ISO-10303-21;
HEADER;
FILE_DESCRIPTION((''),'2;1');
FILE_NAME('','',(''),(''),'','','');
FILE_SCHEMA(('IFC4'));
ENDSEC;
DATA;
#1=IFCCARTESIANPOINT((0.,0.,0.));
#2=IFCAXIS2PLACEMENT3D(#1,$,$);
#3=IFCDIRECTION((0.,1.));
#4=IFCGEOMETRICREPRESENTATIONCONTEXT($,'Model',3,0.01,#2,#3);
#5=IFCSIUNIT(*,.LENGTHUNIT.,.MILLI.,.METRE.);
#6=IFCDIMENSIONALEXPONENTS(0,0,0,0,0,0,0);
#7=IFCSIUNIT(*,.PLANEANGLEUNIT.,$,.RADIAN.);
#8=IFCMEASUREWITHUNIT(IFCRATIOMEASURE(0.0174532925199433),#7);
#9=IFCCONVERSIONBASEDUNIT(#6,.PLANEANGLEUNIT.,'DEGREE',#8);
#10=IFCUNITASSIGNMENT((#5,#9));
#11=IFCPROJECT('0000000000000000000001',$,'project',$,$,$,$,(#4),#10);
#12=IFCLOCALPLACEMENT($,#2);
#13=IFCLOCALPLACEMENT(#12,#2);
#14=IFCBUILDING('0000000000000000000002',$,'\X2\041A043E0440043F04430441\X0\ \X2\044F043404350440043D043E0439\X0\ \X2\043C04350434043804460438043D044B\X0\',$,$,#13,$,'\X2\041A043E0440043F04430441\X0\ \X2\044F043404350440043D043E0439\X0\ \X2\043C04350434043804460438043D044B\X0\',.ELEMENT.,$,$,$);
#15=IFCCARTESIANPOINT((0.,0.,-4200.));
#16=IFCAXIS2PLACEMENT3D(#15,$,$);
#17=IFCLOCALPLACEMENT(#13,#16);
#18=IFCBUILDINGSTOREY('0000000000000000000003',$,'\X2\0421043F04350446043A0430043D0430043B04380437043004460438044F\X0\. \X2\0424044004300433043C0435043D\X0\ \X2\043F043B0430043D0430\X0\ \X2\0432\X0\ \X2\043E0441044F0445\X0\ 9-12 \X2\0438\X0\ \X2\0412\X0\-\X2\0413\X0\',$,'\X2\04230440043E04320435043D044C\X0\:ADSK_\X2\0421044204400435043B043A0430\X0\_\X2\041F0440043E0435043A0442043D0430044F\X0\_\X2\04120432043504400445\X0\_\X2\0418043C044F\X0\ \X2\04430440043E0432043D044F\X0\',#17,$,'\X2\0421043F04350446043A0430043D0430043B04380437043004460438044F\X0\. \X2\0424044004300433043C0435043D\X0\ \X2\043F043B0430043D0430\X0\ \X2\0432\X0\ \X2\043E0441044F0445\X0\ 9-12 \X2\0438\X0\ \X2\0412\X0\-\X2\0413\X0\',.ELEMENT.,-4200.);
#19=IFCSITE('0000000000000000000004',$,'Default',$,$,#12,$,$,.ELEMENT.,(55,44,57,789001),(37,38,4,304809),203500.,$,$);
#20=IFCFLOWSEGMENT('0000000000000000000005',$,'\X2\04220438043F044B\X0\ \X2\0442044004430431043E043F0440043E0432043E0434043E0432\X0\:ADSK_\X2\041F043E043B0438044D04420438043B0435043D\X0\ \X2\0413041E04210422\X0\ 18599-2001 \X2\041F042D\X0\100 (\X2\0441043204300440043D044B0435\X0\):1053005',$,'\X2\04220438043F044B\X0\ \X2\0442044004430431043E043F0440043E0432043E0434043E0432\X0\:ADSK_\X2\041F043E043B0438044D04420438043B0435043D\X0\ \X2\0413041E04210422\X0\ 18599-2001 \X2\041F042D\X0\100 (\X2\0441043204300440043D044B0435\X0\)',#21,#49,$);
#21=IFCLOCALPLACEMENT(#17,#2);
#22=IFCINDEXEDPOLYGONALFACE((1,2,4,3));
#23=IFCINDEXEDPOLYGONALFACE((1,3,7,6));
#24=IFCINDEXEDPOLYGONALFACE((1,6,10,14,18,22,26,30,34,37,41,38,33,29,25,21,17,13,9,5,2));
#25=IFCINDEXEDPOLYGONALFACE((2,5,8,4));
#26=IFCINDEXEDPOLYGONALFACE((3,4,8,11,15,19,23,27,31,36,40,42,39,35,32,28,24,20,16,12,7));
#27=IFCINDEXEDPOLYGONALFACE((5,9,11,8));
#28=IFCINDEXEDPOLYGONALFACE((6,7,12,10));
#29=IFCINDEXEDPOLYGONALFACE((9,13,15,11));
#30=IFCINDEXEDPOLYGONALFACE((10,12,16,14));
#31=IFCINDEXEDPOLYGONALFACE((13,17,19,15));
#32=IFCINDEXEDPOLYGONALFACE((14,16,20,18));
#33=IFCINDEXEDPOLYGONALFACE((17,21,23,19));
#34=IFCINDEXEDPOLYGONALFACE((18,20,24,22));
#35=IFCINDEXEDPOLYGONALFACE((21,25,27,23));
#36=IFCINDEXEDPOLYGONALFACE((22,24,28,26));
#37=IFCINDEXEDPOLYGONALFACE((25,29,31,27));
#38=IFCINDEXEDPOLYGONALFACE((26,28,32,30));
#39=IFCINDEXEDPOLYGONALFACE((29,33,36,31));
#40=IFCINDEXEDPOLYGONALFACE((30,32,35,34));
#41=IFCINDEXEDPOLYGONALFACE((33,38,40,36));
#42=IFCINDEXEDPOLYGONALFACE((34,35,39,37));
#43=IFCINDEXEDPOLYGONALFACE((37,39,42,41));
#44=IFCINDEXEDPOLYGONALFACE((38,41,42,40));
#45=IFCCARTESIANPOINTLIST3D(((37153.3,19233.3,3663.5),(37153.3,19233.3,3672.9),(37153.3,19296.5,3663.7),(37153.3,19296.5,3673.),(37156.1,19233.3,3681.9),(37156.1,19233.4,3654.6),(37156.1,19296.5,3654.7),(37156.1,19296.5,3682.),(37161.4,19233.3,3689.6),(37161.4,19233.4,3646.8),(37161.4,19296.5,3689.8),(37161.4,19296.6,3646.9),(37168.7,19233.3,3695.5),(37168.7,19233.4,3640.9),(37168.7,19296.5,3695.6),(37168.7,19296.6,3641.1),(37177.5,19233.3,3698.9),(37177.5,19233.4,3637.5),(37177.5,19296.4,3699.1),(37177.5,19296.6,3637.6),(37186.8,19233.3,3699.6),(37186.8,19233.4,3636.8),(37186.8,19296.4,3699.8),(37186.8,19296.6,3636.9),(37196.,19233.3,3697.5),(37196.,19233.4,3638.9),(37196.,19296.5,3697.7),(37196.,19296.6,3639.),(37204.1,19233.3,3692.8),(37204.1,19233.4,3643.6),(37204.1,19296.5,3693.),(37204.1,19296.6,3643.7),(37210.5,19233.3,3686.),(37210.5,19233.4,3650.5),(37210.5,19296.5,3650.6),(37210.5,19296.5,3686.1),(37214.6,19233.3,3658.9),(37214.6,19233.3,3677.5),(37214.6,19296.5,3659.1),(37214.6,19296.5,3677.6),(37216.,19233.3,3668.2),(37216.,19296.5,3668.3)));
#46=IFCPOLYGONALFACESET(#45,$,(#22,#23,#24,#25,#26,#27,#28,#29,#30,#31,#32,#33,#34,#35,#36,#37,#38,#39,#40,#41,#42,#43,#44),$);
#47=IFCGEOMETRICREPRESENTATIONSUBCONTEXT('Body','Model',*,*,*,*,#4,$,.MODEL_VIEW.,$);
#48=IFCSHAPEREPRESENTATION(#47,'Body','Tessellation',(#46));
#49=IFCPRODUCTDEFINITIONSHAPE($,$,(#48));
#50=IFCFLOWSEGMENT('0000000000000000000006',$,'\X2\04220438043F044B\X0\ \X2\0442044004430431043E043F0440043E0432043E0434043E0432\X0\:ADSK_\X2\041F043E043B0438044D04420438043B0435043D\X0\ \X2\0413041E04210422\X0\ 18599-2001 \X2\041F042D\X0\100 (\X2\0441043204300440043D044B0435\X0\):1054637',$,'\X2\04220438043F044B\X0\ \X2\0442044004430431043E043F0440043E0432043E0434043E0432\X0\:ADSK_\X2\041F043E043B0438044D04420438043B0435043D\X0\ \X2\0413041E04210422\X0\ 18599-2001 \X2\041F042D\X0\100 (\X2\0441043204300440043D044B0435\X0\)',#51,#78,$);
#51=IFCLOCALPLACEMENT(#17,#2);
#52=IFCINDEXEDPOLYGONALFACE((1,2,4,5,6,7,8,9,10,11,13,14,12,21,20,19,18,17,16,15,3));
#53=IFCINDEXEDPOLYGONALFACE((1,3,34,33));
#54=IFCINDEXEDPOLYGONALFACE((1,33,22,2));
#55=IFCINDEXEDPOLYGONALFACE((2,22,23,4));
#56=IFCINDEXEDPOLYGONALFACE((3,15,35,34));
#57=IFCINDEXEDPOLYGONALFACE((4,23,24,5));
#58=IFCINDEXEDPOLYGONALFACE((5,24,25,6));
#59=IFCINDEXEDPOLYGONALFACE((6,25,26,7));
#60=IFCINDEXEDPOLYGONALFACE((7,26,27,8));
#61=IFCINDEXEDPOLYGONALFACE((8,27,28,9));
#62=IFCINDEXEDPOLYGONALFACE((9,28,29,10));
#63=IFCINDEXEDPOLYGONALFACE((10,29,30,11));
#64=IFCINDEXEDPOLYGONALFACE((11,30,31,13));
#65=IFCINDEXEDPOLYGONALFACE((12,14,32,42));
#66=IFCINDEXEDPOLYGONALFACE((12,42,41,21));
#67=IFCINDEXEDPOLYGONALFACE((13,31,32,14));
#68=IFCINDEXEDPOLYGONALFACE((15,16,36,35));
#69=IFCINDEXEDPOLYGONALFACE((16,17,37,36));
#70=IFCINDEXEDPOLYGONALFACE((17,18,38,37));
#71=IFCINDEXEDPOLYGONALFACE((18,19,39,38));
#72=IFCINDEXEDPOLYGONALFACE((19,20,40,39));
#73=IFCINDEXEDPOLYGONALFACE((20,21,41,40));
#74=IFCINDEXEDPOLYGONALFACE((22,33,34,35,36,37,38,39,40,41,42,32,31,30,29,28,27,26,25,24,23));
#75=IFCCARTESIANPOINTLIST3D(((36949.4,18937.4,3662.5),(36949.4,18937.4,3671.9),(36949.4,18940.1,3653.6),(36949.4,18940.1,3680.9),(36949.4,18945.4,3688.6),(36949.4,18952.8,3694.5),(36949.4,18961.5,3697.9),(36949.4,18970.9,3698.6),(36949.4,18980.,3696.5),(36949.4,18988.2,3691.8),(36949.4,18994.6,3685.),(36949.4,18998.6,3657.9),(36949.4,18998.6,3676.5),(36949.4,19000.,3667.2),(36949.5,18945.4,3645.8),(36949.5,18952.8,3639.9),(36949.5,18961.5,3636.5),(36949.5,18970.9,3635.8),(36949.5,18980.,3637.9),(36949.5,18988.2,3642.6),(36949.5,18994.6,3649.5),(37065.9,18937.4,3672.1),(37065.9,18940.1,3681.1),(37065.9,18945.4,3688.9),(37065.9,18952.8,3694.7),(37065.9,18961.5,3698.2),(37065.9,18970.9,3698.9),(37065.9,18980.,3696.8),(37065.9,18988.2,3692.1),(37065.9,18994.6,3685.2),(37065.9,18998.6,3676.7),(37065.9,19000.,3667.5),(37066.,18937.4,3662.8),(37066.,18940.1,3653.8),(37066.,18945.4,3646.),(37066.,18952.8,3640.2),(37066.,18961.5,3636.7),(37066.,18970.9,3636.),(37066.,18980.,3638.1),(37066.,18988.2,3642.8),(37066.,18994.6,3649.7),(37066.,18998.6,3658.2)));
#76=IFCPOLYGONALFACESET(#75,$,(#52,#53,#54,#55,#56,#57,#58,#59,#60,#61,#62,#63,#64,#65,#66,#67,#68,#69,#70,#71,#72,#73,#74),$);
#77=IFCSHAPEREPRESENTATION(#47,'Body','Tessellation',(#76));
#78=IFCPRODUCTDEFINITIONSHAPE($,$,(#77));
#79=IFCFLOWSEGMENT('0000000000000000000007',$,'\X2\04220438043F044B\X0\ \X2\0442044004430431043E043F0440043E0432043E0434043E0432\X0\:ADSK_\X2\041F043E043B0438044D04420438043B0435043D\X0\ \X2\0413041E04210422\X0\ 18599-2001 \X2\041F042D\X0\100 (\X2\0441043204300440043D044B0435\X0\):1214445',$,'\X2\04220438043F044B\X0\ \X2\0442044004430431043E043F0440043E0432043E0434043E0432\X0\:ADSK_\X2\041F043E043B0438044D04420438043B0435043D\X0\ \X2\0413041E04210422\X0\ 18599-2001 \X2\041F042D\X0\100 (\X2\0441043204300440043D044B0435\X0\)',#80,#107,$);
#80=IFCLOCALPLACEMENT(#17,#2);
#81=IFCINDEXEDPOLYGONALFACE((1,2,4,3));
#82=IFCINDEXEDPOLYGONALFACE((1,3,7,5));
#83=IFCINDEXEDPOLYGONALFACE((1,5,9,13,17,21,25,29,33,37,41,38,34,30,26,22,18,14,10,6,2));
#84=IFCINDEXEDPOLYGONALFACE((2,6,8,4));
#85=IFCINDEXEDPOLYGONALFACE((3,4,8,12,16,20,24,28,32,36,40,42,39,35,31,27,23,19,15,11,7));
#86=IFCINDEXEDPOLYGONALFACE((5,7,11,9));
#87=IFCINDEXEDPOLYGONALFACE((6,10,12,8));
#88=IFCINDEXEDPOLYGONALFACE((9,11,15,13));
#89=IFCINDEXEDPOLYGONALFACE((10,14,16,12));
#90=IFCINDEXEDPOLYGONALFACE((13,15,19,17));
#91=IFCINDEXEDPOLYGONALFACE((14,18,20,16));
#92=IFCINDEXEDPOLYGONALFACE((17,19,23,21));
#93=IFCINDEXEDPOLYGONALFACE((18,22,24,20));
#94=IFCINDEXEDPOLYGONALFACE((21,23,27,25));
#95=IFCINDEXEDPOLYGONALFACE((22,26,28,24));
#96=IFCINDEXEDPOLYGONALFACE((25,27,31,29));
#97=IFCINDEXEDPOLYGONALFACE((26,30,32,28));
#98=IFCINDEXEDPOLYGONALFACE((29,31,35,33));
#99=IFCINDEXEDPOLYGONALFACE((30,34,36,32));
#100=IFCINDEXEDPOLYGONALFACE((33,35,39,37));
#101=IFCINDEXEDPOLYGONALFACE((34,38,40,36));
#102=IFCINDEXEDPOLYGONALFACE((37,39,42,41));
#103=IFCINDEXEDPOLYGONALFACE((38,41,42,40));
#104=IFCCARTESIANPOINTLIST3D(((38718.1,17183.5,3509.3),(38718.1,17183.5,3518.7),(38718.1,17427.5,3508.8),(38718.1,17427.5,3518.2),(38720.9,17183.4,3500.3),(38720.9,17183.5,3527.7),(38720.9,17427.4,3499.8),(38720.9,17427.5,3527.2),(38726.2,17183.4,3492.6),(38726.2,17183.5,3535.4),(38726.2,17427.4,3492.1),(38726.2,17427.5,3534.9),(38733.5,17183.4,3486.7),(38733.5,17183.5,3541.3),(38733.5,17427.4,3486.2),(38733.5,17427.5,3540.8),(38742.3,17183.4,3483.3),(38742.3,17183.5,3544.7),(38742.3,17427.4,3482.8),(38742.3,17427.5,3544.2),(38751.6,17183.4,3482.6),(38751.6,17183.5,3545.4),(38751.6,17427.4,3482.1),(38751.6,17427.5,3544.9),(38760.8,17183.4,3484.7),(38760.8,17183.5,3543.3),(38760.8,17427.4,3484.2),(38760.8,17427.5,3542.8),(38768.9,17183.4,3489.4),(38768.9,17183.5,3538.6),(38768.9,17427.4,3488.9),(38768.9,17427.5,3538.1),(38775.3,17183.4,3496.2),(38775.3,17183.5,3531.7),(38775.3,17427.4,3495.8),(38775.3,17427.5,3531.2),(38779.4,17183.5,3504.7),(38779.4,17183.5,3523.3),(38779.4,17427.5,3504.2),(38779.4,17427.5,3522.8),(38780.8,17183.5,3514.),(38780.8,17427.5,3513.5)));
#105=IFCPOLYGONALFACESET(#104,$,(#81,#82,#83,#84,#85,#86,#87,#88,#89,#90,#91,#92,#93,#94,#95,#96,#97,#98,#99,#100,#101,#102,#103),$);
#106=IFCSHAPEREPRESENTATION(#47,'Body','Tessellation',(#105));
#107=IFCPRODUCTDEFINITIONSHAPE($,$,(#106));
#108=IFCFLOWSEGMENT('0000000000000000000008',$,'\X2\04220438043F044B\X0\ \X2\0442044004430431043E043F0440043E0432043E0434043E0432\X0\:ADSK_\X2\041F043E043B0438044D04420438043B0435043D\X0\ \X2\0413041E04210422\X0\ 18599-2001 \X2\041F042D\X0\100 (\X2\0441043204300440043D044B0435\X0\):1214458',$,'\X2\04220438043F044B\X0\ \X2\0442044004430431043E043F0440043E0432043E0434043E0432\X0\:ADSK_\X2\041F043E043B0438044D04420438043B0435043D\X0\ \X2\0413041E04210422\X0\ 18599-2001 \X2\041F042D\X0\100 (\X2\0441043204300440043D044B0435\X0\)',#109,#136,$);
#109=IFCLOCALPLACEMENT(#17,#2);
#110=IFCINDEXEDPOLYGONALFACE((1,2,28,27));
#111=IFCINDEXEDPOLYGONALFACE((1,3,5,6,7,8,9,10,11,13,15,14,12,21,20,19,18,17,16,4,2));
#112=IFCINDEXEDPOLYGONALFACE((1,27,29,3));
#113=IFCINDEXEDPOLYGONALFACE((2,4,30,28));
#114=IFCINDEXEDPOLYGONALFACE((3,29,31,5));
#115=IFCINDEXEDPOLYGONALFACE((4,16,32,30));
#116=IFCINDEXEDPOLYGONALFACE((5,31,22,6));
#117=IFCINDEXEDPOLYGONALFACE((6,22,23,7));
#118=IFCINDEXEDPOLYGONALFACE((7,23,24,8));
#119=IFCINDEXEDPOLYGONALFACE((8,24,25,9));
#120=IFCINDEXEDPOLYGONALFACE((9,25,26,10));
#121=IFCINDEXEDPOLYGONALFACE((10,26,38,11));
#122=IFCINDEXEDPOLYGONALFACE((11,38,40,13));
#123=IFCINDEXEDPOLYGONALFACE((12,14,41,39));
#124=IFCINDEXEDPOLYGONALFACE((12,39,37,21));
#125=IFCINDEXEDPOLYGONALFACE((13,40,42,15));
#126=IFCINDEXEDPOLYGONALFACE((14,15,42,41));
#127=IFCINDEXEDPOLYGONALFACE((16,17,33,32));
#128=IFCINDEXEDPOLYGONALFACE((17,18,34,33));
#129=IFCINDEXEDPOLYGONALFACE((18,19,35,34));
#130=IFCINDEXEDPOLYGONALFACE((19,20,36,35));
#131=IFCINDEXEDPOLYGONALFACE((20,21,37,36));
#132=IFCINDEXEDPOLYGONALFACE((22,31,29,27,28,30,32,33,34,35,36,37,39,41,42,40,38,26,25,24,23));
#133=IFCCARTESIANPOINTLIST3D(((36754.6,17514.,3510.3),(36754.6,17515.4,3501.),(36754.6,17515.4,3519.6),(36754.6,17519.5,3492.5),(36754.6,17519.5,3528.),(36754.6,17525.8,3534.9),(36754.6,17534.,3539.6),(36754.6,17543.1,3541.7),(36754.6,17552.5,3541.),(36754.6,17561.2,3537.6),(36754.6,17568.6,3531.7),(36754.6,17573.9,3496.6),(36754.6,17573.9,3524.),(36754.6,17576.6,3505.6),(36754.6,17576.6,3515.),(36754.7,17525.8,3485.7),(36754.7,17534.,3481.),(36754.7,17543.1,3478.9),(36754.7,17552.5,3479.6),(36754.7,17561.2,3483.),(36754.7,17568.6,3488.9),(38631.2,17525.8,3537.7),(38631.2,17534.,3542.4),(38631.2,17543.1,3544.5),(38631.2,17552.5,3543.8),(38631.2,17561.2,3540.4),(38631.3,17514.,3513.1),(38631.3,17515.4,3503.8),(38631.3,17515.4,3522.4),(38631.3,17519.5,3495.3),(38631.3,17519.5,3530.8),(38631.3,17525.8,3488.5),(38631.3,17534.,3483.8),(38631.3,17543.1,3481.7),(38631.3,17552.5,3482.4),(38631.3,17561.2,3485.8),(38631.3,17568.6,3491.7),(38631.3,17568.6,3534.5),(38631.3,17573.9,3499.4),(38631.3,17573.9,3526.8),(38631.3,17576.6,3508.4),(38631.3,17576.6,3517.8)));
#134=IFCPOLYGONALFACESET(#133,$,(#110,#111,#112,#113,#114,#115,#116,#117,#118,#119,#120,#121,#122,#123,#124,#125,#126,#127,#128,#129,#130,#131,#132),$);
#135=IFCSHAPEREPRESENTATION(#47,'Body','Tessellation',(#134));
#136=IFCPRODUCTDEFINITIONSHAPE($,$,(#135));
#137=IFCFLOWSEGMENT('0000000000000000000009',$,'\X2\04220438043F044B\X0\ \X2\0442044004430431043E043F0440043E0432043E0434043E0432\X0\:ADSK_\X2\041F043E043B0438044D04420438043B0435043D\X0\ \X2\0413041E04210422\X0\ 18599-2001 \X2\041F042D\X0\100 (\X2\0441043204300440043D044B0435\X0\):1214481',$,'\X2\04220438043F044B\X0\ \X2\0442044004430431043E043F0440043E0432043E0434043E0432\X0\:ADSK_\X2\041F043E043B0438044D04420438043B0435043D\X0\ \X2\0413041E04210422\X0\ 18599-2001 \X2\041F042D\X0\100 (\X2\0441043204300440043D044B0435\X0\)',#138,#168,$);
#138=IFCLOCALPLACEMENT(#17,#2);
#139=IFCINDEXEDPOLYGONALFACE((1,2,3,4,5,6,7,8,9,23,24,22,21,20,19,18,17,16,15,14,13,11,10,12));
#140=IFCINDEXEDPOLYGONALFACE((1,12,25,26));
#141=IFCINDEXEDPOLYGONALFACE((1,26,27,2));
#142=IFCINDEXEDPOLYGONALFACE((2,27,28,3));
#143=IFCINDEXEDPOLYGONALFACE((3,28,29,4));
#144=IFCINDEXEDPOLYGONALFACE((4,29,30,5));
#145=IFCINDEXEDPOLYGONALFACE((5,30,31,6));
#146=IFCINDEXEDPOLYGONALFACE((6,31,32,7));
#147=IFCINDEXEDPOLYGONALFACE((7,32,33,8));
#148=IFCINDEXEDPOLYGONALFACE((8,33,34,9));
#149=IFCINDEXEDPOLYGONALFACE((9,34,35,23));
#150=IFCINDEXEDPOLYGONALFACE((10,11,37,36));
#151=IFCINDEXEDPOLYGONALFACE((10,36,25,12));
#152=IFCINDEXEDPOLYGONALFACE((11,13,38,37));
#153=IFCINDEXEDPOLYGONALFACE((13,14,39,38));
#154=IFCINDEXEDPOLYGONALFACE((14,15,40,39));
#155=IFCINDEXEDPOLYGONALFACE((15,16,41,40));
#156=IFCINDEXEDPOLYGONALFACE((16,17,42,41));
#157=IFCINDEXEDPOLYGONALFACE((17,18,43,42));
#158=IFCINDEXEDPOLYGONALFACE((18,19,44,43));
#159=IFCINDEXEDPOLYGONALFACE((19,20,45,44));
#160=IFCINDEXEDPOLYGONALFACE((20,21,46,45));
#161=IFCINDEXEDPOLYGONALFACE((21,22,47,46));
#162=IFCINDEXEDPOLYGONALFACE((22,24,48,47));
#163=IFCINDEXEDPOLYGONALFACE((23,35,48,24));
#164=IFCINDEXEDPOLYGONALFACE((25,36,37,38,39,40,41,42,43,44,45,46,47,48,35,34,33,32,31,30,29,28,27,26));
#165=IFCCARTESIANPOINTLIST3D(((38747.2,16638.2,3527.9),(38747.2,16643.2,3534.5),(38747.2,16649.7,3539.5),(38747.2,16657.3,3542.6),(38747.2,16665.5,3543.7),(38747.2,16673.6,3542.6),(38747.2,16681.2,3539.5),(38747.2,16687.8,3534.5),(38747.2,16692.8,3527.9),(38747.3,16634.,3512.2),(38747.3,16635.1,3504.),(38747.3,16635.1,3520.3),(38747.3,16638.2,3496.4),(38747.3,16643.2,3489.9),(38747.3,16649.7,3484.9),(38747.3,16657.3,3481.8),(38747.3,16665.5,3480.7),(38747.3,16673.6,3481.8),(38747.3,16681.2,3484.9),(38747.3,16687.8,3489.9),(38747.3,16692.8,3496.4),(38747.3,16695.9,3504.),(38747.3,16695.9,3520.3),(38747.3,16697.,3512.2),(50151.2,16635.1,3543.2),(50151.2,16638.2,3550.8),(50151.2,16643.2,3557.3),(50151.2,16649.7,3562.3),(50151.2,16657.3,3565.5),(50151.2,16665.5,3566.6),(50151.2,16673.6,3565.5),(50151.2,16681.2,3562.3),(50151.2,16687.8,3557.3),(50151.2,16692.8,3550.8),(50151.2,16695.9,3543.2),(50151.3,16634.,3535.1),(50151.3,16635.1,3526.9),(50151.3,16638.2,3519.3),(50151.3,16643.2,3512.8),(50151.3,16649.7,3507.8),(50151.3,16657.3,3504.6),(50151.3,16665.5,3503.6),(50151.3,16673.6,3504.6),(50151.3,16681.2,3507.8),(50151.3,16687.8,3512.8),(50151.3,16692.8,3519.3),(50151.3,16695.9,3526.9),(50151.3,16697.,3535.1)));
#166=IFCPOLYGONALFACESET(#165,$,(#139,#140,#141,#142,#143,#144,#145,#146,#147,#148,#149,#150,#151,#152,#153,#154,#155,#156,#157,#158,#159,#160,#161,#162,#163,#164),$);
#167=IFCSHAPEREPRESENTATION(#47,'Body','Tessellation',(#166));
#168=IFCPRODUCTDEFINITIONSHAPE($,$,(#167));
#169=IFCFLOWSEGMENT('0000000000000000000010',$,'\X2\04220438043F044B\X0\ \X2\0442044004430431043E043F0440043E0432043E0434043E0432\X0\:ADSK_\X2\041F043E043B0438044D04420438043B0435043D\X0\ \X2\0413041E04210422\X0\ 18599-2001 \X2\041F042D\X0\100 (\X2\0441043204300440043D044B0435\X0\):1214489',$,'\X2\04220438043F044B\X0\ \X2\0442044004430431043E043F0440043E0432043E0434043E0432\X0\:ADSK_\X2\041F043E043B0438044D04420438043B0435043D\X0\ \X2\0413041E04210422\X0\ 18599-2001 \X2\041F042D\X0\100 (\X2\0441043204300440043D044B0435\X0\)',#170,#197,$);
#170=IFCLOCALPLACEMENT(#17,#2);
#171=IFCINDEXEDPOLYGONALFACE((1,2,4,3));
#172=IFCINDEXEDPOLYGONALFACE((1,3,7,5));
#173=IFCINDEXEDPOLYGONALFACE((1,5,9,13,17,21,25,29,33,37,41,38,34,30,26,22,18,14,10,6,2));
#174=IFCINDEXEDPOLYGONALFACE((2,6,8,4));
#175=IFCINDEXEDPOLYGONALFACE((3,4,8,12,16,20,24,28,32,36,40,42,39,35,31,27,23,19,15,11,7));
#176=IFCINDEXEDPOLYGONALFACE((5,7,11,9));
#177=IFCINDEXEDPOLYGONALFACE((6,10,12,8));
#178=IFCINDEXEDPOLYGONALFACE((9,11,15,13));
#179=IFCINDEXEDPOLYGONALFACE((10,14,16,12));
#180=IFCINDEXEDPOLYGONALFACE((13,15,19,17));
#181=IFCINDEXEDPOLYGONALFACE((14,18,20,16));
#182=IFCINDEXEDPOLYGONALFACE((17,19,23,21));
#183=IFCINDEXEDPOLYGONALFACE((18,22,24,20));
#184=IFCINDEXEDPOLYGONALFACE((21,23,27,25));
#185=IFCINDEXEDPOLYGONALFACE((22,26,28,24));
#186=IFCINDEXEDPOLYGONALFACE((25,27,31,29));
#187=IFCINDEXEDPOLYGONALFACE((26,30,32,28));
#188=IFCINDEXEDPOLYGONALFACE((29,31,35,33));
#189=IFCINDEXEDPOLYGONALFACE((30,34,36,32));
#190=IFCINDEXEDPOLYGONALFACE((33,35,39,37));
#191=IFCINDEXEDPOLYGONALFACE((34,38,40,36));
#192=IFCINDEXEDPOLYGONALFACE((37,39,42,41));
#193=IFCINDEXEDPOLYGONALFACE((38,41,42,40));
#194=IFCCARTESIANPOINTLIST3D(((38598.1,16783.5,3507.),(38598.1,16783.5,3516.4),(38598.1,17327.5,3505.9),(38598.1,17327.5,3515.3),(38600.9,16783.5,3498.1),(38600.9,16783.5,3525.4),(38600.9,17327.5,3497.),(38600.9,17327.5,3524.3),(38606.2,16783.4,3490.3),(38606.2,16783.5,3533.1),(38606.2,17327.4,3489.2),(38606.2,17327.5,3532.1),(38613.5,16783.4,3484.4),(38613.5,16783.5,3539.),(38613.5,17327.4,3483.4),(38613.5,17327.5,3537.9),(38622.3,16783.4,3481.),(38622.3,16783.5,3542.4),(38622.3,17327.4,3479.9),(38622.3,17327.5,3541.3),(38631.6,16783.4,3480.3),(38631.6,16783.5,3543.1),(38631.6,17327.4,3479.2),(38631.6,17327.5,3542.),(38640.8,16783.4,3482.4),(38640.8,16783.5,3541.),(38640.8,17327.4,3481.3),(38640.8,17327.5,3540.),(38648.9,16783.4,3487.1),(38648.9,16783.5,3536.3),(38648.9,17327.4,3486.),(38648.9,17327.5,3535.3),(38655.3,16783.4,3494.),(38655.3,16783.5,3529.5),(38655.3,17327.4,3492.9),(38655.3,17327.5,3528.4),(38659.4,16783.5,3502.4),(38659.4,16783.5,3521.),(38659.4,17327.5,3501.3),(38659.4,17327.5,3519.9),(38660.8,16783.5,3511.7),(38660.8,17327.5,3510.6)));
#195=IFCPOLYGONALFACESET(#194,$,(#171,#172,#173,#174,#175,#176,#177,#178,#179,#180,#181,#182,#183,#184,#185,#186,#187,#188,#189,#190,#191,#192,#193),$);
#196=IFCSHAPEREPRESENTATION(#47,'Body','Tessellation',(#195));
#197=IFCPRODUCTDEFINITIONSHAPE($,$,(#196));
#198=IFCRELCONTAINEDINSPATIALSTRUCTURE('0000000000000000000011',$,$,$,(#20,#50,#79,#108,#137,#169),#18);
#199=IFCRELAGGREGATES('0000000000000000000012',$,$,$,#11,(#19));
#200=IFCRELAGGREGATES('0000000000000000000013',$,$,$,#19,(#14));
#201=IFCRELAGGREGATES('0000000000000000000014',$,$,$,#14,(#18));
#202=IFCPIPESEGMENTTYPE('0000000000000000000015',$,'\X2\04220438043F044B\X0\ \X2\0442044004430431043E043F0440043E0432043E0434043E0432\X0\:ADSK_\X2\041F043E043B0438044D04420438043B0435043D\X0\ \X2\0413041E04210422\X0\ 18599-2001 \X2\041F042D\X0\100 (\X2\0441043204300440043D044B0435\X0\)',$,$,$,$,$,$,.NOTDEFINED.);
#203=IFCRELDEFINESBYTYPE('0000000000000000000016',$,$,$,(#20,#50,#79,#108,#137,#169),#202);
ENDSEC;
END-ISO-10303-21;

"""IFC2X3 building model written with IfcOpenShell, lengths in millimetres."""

from ifc_helpers import new_model, entity, si_unit, converted_unit, direction, frame, origin, origin_2d_with_axis, place, context, subcontext, project, spatial, polyline, circle, outline, extrude, type_object, element, save


model = new_model("IFC2X3")

# Units and contexts
model_context = context("Model", 3, precision=0.01, world=origin(), true_north=direction((0.0, 1.0)))
body_context = subcontext(model_context, "Body", "Model", "MODEL_VIEW")
ifc_project = project(units=[si_unit("LENGTHUNIT", "METRE", prefix="MILLI"), converted_unit("PLANEANGLEUNIT", "DEGREE", entity("IfcRatioMeasure", 0.0174532925199433), si_unit("PLANEANGLEUNIT", "RADIAN"), dimensions=[0, 0, 0, 0, 0, 0, 0])], contexts=[model_context])

# Site, building, storey
site_placement = place(None, origin())
site = spatial("IfcSite", under=ifc_project, at=site_placement, Name="Default", CompositionType="ELEMENT", RefLatitude=(55, 44, 57, 789001), RefLongitude=(37, 38, 4, 304809), RefElevation=203500.0)
building_placement = place(site_placement, origin())
building = spatial("IfcBuilding", under=site, at=building_placement, Name="Корпус ядерной медицины", LongName="Корпус ядерной медицины", CompositionType="ELEMENT")
storey_placement = place(building_placement, frame((0.0, 0.0, -4200.0)))
storey = spatial("IfcBuildingStorey", under=building, at=storey_placement, Name="Спецканализация. Фрагмен плана в осях 9-12 и В-Г", ObjectType="Уровень:ADSK_Стрелка_Проектная_Вверх_Имя уровня", LongName="Спецканализация. Фрагмен плана в осях 9-12 и В-Г", CompositionType="ELEMENT", Elevation=-4200.0)

# Flow segments
pipe_segment_type = type_object("IfcPipeSegmentType", Name="Типы трубопроводов:ADSK_Полиэтилен ГОСТ 18599-2001 ПЭ100 (сварные)", PredefinedType="NOTDEFINED")
flow_segment_1_placement = place(storey_placement, frame((37151.4, 19233.3, 3635.1)))
element("IfcFlowSegment", 1, at=flow_segment_1_placement, inside=storey, type_object=pipe_segment_type, Name="Типы трубопроводов:ADSK_Полиэтилен ГОСТ 18599-2001 ПЭ100 (сварные):1053005", ObjectType="Типы трубопроводов:ADSK_Полиэтилен ГОСТ 18599-2001 ПЭ100 (сварные)", context=body_context, shape_type="SweptSolid", body=[
    extrude(circle(Radius=31.5, at=origin_2d_with_axis()), frame((33.1, 0.1, 33.1), z_axis=(0.0, 0.999998, 0.002007), x_axis=(1.0, 0.0, 0.0)), (0.0, 0.0, 1.0), 63.2),
])
flow_segment_2_placement = place(storey_placement, frame((36949.4, 18935.4, 3634.1)))
element("IfcFlowSegment", 2, at=flow_segment_2_placement, inside=storey, type_object=pipe_segment_type, Name="Типы трубопроводов:ADSK_Полиэтилен ГОСТ 18599-2001 ПЭ100 (сварные):1054637", ObjectType="Типы трубопроводов:ADSK_Полиэтилен ГОСТ 18599-2001 ПЭ100 (сварные)", context=body_context, shape_type="SweptSolid", body=[
    extrude(circle(Radius=31.5, at=origin_2d_with_axis()), frame((0.1, 33.1, 33.1), z_axis=(0.999998, 0.0, 0.002), x_axis=(0.0, 1.0, 0.0)), (0.0, 0.0, 1.0), 116.5),
])
flow_segment_3_placement = place(storey_placement, frame((38716.2, 17183.4, 3480.4)))
element("IfcFlowSegment", 3, at=flow_segment_3_placement, inside=storey, type_object=pipe_segment_type, Name="Типы трубопроводов:ADSK_Полиэтилен ГОСТ 18599-2001 ПЭ100 (сварные):1214445", ObjectType="Типы трубопроводов:ADSK_Полиэтилен ГОСТ 18599-2001 ПЭ100 (сварные)", context=body_context, shape_type="SweptSolid", body=[
    extrude(circle(Radius=31.5, at=origin_2d_with_axis()), frame((33.1, 244.1, 33.1), z_axis=(0.0, -0.999998, 0.002), x_axis=(1.0, 0.0, 0.0)), (0.0, 0.0, 1.0), 244.0),
])
flow_segment_4_placement = place(storey_placement, frame((36754.6, 17512.4, 3477.2)))
element("IfcFlowSegment", 4, at=flow_segment_4_placement, inside=storey, type_object=pipe_segment_type, Name="Типы трубопроводов:ADSK_Полиэтилен ГОСТ 18599-2001 ПЭ100 (сварные):1214458", ObjectType="Типы трубопроводов:ADSK_Полиэтилен ГОСТ 18599-2001 ПЭ100 (сварные)", context=body_context, shape_type="SweptSolid", body=[
    extrude(circle(Radius=31.5, at=origin_2d_with_axis()), frame((0.1, 33.1, 33.1), z_axis=(0.999999, 0.0, 0.001491), x_axis=(0.0, -1.0, 0.0)), (0.0, 0.0, 1.0), 1876.7),
])
flow_segment_5_placement = place(storey_placement, frame((38747.2, 16632.4, 3479.1)))
element("IfcFlowSegment", 5, at=flow_segment_5_placement, inside=storey, type_object=pipe_segment_type, Name="Типы трубопроводов:ADSK_Полиэтилен ГОСТ 18599-2001 ПЭ100 (сварные):1214481", ObjectType="Типы трубопроводов:ADSK_Полиэтилен ГОСТ 18599-2001 ПЭ100 (сварные)", context=body_context, shape_type="SweptSolid", body=[
    extrude(outline(polyline([(-4.1, -31.2), (4.1, -31.2), (12.1, -29.1), (19.2, -25.0), (25.0, -19.2), (29.1, -12.1), (31.2, -4.1), (31.2, 4.1), (29.1, 12.1), (25.0, 19.2), (19.2, 25.0), (12.1, 29.1), (4.1, 31.2), (-4.1, 31.2), (-12.1, 29.1), (-19.2, 25.0), (-25.0, 19.2), (-29.1, 12.1), (-31.2, 4.1), (-31.2, -4.1), (-29.1, -12.1), (-25.0, -19.2), (-19.2, -25.0), (-12.1, -29.1), (-4.1, -31.2)])), frame((0.1, 33.1, 33.1), z_axis=(0.999998, 0.0, 0.002005), x_axis=(-0.001988, -0.130526, 0.991443)), (0.0, 0.0, 1.0), 11404.0),
])
flow_segment_6_placement = place(storey_placement, frame((38596.2, 16783.4, 3477.5)))
element("IfcFlowSegment", 6, at=flow_segment_6_placement, inside=storey, type_object=pipe_segment_type, Name="Типы трубопроводов:ADSK_Полиэтилен ГОСТ 18599-2001 ПЭ100 (сварные):1214489", ObjectType="Типы трубопроводов:ADSK_Полиэтилен ГОСТ 18599-2001 ПЭ100 (сварные)", context=body_context, shape_type="SweptSolid", body=[
    extrude(circle(Radius=31.5, at=origin_2d_with_axis()), frame((33.1, 544.1, 33.1), z_axis=(0.0, -0.999998, 0.002), x_axis=(1.0, 0.0, 0.0)), (0.0, 0.0, 1.0), 544.0),
])

save(model, "model.ifc")
